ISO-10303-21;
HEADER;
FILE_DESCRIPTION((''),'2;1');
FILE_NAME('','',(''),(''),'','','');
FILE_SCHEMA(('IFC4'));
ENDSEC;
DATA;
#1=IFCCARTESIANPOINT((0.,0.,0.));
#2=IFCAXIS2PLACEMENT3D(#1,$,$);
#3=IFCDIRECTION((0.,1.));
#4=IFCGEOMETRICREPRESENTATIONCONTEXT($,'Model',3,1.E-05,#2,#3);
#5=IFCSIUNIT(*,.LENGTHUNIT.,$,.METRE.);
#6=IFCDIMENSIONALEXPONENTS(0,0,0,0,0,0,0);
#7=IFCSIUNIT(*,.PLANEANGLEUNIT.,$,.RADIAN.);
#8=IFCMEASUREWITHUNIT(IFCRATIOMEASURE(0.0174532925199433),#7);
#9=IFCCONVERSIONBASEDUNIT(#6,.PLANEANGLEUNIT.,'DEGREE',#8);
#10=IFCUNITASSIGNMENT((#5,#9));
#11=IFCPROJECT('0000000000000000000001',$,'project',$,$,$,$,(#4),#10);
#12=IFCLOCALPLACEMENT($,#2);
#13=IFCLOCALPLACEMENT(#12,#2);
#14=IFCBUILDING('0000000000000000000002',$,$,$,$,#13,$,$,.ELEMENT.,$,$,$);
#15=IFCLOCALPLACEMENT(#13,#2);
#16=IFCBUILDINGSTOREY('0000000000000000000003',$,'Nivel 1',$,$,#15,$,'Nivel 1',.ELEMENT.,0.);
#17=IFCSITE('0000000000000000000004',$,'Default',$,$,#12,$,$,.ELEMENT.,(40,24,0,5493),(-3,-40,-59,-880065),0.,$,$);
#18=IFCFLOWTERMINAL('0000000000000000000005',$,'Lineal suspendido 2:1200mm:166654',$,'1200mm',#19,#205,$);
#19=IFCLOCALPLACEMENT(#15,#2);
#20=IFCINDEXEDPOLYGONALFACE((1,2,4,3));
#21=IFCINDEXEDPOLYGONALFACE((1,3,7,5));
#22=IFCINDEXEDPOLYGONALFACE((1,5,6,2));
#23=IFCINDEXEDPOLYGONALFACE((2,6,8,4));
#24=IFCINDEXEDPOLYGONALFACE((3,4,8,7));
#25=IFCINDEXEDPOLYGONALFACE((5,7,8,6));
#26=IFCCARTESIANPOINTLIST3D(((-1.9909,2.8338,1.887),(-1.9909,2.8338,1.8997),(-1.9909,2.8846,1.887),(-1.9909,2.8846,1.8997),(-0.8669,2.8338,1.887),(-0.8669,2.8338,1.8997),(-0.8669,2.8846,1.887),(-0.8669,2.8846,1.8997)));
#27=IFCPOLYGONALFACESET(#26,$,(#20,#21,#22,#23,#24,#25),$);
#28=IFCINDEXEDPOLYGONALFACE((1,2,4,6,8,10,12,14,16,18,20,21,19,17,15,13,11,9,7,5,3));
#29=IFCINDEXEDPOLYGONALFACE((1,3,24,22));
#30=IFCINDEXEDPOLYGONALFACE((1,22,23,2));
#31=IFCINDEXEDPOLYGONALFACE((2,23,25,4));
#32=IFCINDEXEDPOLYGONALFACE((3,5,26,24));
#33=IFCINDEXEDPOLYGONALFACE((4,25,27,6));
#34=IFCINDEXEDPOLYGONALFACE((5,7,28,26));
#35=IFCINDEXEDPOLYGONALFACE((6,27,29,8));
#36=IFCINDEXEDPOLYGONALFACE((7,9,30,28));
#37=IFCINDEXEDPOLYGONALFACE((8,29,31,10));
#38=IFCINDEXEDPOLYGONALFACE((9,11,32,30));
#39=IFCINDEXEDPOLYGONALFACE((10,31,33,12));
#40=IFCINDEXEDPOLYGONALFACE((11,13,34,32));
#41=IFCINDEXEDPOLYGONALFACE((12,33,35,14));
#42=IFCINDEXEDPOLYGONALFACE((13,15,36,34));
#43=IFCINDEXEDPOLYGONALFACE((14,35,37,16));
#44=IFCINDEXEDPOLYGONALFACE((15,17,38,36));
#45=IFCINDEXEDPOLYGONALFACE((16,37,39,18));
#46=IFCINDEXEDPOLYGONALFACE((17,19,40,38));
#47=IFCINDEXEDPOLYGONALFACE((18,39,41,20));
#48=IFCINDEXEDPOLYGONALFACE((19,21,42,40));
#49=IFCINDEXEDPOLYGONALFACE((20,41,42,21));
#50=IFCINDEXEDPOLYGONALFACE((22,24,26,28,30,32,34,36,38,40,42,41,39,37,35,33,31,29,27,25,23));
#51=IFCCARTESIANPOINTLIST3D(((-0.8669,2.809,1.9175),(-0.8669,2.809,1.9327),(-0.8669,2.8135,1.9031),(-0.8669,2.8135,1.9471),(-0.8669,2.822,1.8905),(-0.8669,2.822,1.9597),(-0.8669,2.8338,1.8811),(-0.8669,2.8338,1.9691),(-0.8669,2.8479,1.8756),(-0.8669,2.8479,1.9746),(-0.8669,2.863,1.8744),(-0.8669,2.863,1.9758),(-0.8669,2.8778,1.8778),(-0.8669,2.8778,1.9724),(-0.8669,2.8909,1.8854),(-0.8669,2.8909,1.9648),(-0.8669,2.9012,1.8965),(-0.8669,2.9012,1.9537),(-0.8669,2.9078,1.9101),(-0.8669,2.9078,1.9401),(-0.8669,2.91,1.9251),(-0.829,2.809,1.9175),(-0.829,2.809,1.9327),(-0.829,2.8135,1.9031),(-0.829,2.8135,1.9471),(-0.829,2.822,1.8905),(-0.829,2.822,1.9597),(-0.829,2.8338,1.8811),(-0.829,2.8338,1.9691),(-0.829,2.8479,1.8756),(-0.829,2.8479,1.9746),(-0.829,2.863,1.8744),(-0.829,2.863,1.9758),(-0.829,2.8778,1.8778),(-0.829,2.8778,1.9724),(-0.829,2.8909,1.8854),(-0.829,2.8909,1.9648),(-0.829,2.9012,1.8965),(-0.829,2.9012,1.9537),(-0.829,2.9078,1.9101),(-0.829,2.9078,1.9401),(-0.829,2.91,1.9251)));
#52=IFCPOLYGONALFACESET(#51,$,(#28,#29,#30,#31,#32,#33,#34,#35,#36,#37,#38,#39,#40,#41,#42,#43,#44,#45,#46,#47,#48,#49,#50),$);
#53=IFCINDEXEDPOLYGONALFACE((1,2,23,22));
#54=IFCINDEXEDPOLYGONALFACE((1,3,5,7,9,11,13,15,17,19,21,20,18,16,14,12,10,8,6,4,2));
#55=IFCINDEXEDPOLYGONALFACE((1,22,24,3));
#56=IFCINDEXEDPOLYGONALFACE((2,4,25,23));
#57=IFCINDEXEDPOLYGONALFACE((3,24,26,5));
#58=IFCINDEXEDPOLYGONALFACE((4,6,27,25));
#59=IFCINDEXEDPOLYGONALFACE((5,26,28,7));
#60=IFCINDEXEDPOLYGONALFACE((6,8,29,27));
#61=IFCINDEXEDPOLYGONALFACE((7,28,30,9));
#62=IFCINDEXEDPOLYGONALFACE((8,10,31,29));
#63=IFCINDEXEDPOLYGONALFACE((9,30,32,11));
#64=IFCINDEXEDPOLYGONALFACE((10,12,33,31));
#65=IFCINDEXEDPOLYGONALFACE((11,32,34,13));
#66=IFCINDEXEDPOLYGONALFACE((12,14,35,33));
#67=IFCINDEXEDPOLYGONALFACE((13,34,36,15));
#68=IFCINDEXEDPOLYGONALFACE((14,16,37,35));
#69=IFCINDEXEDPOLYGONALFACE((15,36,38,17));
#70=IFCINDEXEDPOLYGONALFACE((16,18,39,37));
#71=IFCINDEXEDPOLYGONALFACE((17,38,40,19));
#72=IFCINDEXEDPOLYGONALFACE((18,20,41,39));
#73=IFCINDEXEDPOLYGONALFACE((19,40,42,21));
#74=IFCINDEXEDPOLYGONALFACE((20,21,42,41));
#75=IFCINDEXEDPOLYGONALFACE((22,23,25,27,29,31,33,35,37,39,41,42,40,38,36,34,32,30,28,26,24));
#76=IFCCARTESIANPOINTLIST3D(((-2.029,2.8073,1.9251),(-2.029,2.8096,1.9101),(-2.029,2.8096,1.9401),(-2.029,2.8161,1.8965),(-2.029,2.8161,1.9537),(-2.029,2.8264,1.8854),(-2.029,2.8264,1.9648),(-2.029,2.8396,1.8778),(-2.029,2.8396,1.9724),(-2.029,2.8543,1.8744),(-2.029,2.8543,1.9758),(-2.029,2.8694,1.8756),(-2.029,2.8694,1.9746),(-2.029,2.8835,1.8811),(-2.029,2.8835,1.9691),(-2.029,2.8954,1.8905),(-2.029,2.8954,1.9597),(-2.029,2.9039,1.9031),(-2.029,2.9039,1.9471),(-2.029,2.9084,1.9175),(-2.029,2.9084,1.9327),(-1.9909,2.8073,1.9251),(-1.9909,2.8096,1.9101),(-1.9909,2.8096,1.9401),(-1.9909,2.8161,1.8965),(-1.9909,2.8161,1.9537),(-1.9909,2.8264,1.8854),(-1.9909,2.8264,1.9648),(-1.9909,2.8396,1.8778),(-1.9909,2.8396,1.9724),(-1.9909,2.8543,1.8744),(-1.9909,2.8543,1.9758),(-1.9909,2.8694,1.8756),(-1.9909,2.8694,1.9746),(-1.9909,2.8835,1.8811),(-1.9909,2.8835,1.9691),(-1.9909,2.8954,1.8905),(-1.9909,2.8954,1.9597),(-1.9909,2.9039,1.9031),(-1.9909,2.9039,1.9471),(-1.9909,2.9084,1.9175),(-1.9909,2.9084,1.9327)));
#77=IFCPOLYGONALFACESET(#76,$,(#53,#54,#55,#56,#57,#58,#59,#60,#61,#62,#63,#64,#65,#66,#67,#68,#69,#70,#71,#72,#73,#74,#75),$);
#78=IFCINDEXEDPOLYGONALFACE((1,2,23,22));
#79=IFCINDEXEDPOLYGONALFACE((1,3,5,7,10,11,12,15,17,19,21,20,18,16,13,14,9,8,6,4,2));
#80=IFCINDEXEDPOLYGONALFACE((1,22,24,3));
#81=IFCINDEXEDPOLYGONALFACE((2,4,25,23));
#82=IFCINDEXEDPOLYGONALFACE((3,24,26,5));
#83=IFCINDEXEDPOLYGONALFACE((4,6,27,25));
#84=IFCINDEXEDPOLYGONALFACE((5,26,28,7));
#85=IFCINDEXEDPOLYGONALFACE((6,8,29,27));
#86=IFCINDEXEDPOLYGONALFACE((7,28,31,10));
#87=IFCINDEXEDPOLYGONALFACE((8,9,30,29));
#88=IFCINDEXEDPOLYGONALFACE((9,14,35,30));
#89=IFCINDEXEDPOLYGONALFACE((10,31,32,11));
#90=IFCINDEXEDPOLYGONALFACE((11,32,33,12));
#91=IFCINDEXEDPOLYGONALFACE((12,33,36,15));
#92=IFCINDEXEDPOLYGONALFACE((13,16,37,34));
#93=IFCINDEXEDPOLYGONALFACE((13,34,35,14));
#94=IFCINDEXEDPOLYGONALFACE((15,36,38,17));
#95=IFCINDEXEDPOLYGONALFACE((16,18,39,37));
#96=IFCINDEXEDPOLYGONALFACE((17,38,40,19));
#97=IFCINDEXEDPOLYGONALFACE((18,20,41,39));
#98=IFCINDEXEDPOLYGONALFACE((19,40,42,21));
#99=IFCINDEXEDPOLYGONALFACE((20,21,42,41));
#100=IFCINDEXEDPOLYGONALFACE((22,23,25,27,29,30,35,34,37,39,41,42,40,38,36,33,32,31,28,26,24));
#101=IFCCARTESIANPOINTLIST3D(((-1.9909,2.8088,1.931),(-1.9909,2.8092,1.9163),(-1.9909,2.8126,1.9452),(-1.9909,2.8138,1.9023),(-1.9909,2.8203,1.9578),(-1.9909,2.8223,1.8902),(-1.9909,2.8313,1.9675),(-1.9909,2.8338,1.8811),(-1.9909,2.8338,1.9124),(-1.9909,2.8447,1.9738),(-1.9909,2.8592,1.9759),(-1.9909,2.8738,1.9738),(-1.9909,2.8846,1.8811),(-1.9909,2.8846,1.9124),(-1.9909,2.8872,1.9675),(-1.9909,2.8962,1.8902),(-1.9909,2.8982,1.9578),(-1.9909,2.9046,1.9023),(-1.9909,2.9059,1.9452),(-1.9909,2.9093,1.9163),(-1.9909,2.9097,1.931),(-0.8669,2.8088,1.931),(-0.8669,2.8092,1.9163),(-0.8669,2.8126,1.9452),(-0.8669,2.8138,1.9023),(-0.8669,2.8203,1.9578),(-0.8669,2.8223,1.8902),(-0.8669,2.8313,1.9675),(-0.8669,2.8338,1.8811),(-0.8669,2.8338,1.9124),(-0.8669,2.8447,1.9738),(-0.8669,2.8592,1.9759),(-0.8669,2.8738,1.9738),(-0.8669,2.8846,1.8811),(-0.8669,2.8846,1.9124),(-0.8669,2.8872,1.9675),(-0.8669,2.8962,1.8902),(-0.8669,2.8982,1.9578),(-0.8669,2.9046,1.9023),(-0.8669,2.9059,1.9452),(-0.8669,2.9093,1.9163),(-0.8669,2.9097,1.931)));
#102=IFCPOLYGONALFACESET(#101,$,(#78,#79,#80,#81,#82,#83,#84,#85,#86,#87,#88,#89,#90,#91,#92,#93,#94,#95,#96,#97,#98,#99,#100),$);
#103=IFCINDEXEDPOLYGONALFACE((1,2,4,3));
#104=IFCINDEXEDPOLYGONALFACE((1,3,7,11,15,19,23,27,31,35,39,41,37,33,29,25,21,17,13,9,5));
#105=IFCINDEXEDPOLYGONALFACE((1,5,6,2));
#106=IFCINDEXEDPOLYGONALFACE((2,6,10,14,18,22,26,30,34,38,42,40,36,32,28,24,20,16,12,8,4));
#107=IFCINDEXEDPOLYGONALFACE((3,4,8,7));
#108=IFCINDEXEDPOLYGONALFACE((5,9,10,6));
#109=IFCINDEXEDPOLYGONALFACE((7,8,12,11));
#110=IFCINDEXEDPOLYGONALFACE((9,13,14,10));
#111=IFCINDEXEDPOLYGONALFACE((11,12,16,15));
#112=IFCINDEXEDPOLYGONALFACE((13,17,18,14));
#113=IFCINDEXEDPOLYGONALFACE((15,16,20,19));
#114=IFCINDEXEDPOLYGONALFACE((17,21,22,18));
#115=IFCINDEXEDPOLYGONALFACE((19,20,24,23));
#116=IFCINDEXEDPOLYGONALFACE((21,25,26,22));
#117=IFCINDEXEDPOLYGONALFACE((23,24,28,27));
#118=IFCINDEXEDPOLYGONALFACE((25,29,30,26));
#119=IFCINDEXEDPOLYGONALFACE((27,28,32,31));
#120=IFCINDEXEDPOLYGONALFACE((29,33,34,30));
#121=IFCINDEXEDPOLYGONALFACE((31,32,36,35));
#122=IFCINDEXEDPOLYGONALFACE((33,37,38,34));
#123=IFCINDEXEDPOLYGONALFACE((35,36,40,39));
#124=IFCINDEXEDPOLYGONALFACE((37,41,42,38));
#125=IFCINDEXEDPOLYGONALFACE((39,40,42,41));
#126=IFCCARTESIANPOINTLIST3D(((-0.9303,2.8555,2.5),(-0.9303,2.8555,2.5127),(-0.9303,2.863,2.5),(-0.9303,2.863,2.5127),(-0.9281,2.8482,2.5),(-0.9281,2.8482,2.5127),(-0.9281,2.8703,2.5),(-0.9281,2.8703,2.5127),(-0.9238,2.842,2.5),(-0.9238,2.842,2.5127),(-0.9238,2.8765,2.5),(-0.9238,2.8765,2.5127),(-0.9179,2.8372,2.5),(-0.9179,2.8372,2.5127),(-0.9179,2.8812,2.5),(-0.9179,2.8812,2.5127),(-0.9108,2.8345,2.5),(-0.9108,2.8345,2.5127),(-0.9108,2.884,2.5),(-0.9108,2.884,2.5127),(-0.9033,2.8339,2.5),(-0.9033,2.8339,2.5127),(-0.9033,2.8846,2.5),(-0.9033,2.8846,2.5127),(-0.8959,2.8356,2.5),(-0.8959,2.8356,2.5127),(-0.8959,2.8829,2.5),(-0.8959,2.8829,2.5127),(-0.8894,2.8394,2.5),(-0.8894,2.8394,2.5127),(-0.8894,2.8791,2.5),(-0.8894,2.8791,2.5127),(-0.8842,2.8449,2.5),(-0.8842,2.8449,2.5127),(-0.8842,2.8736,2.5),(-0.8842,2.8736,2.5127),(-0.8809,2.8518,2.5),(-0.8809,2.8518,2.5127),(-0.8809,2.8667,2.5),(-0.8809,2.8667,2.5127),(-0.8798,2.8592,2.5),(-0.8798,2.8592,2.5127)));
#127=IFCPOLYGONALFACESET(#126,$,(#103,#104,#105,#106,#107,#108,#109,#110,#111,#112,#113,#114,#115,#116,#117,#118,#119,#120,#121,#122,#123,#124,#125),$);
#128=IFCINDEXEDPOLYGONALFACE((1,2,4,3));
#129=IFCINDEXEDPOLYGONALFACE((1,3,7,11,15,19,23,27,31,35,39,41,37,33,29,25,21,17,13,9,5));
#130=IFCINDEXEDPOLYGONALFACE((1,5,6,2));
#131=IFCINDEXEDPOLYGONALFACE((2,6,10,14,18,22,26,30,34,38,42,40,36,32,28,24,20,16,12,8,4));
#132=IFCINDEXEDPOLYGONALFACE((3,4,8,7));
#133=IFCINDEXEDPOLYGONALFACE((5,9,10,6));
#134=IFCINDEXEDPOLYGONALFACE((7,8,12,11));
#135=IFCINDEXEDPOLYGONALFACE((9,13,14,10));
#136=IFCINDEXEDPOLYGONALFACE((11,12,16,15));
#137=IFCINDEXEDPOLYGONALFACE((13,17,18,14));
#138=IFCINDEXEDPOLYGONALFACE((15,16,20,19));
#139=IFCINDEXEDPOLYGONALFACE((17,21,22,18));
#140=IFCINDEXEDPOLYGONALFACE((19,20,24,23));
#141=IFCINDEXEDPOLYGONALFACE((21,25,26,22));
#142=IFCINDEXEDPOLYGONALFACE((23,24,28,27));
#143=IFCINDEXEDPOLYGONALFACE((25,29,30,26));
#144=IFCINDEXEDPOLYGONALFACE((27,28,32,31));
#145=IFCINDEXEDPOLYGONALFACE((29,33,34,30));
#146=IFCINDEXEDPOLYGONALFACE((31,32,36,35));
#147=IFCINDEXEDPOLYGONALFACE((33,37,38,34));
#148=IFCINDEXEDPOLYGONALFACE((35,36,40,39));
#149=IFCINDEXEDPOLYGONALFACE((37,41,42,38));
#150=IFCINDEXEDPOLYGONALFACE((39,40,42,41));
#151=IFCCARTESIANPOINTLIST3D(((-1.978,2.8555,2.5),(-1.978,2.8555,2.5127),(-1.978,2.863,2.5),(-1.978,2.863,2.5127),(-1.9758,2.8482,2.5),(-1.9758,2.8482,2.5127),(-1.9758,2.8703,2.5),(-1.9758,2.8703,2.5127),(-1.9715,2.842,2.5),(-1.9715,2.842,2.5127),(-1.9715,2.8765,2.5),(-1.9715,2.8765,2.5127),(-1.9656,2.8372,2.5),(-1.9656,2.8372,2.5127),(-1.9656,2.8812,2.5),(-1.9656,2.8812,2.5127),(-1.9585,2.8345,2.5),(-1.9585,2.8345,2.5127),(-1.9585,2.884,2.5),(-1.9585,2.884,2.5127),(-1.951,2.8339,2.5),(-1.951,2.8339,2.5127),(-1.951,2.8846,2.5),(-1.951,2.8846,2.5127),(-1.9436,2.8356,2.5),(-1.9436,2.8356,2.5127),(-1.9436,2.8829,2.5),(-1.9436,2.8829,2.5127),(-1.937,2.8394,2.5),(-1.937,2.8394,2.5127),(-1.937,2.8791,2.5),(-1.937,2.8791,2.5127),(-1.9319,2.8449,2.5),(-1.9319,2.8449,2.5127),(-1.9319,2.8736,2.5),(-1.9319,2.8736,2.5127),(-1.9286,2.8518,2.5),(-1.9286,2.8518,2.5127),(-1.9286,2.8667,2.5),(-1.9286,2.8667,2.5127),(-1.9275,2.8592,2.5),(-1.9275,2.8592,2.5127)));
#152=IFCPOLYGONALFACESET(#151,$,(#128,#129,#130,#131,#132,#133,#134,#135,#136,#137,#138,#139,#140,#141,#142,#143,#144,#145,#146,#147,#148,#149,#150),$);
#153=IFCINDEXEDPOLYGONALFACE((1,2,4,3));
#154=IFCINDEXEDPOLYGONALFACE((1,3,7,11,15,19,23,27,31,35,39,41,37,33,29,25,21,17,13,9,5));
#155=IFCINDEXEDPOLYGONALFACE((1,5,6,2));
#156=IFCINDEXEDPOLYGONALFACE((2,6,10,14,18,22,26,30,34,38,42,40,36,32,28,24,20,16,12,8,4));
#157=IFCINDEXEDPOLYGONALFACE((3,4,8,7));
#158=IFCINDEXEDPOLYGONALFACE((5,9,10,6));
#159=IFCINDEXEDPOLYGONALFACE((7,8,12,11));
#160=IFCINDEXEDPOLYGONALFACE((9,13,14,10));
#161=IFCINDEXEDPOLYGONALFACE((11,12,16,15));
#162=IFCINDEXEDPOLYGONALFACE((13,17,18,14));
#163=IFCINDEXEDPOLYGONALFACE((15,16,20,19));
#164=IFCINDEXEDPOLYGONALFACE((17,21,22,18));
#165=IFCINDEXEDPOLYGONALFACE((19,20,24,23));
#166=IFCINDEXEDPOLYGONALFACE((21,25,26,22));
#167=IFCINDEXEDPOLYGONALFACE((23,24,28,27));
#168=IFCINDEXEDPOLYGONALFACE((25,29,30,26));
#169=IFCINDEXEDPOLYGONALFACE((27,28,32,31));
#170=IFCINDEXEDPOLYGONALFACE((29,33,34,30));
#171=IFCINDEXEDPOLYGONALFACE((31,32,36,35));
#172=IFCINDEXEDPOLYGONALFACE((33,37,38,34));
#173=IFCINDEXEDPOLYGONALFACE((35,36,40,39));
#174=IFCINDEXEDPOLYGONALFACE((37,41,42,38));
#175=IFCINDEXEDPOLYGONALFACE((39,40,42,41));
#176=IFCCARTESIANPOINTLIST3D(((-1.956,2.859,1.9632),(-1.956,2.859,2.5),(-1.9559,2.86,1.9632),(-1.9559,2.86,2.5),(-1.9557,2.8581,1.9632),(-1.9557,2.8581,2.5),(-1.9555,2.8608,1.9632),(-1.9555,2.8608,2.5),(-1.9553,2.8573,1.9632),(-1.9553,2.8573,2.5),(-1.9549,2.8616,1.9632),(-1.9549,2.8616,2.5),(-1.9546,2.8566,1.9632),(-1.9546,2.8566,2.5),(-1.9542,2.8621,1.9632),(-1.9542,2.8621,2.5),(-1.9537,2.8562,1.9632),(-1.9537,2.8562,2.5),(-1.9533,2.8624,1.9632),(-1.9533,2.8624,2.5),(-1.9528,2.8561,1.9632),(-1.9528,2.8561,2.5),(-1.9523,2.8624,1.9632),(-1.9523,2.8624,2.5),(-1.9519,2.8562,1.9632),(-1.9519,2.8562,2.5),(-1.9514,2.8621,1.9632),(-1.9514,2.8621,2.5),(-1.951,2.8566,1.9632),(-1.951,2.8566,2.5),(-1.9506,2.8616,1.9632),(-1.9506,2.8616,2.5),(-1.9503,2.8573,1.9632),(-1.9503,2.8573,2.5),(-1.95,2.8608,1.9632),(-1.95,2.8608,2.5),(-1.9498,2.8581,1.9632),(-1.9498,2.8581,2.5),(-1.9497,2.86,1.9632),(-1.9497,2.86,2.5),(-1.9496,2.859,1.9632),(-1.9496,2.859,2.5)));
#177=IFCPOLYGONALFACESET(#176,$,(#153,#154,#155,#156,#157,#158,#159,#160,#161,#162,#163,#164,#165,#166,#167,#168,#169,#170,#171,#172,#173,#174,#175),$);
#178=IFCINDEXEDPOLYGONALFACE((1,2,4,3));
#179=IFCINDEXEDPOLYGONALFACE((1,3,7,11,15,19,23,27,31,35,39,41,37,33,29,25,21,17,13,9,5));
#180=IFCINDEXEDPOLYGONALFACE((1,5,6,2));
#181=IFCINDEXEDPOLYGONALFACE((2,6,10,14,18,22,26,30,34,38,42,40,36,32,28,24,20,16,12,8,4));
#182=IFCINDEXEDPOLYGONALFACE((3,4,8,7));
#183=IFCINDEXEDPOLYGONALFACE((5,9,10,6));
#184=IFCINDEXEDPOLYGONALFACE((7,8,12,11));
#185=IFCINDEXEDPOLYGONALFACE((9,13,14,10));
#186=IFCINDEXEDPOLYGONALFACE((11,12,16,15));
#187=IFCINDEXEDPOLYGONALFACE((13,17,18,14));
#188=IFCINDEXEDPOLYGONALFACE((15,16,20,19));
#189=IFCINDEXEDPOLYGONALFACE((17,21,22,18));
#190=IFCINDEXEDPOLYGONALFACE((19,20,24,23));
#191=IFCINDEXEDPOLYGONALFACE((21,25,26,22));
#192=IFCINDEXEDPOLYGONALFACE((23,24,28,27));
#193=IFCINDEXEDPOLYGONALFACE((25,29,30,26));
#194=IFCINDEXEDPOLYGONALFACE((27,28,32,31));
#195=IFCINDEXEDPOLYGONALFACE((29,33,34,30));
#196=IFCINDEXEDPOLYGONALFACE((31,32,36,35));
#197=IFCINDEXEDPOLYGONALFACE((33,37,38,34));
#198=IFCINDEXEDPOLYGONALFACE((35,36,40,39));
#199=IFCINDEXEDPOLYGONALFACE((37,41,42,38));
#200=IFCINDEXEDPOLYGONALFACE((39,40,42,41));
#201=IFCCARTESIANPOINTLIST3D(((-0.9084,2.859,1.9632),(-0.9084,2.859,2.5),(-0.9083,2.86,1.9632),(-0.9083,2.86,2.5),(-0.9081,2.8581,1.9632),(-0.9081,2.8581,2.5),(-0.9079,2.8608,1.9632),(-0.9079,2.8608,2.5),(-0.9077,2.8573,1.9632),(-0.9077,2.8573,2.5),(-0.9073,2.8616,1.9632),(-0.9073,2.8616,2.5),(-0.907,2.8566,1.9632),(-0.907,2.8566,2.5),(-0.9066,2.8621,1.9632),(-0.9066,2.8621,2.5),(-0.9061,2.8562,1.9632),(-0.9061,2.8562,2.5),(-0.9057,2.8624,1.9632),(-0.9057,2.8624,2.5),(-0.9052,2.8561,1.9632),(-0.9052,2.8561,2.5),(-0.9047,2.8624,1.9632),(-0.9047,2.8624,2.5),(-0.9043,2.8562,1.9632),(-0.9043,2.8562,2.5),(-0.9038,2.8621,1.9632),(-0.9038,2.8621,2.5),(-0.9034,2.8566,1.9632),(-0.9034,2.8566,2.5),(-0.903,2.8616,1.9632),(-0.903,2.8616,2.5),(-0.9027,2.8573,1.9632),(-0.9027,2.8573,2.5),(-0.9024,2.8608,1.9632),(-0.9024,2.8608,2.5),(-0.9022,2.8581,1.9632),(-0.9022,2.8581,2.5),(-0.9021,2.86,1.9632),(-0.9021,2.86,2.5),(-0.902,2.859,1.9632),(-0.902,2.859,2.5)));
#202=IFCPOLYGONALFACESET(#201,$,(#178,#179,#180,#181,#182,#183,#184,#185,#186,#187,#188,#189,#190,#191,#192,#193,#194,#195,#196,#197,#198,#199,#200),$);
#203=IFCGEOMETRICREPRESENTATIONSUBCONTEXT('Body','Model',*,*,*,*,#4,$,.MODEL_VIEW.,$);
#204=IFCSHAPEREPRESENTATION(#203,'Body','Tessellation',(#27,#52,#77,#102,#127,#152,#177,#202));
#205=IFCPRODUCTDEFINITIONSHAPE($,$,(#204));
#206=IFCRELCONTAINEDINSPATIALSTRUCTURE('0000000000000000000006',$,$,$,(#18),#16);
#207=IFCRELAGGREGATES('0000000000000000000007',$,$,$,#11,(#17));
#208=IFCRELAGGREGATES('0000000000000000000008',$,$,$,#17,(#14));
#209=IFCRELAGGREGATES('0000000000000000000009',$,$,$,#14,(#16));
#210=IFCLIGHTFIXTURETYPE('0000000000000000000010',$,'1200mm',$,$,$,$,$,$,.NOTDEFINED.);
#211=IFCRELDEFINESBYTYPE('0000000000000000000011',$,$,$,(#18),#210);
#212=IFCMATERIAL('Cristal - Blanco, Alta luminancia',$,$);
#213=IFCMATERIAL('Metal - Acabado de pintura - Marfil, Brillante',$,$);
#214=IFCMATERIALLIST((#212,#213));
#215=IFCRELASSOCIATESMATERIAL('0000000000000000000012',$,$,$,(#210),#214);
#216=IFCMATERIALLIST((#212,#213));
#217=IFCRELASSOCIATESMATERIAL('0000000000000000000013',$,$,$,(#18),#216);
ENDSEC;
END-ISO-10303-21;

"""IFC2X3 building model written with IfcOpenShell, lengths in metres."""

from ifc_helpers import new_model, entity, si_unit, converted_unit, direction, frame, frame_2d, origin, origin_2d_with_axis, place, context, subcontext, project, spatial, polyline, circle_curve, parameter, trimmed, segment, composite_curve, rectangle, circle, outline, extrude, source, transform, mapped, material, material_list, type_object, type_shapes, element, save


model = new_model("IFC2X3")

# Units and contexts
model_context = context("Model", 3, precision=1e-05, world=origin(), true_north=direction((0.0, 1.0)))
body_context = subcontext(model_context, "Body", "Model", "MODEL_VIEW")
ifc_project = project(units=[si_unit("LENGTHUNIT", "METRE"), converted_unit("PLANEANGLEUNIT", "DEGREE", entity("IfcRatioMeasure", 0.0174532925199433), si_unit("PLANEANGLEUNIT", "RADIAN"), dimensions=[0, 0, 0, 0, 0, 0, 0])], contexts=[model_context])

# Site, building, storey
site_placement = place(None, origin())
site = spatial("IfcSite", under=ifc_project, at=site_placement, Name="Default", CompositionType="ELEMENT", RefLatitude=(40, 24, 0, 5493), RefLongitude=(-3, -40, -59, -880065), RefElevation=0.0)
building_placement = place(site_placement, origin())
building = spatial("IfcBuilding", under=site, at=building_placement, CompositionType="ELEMENT")
storey_placement = place(building_placement, origin())
storey = spatial("IfcBuildingStorey", under=building, at=storey_placement, Name="Nivel 1", LongName="Nivel 1", CompositionType="ELEMENT", Elevation=0.0)

# Flow terminal
ifc_material_1 = material(Name="Cristal - Blanco, Alta luminancia")
ifc_material_2 = material(Name="Metal - Acabado de pintura - Marfil, Brillante")
ifc_material_list_1 = material_list([ifc_material_1, ifc_material_2])
light_fixture_type = type_object("IfcLightFixtureType", Name="1200mm", PredefinedType="NOTDEFINED", material=ifc_material_list_1)
shared_shape = source(origin(), body_context, "Body", "SweptSolid", [
    extrude(rectangle(XDim=1.124, YDim=0.0508, at=origin_2d_with_axis()), frame((0.0001, 0.0, 1.8127), z_axis=(0.0, 0.0, 1.0), x_axis=(-1.0, 0.0, 0.0)), (0.0, 0.0, 1.0), 0.0127),
    extrude(circle(Radius=0.0508, at=frame_2d((0.0, 0.0), x_axis=(1.0, 0.0))), frame((0.5621, 0.0, 1.8508), z_axis=(1.0, 0.0, 0.0), x_axis=(0.0, 1.0, 0.0)), (0.0, 0.0, 1.0), 0.0379),
    extrude(circle(Radius=0.0508, at=frame_2d((0.0, 0.0), x_axis=(1.0, 0.0))), frame((-0.6, -0.0011, 1.8508), z_axis=(1.0, 0.0, 0.0), x_axis=(0.0, -1.0, 0.0)), (0.0, 0.0, 1.0), 0.0381),
    extrude(outline(composite_curve([segment(trimmed(circle_curve(frame_2d((0.0125, 0.0), x_axis=(0.0, 1.0)), 0.0508), [parameter(120.0)], [parameter(270.0)], True, "PARAMETER"), True, "CONTINUOUS"), segment(trimmed(circle_curve(frame_2d((0.0125, 0.0), x_axis=(0.0, 1.0)), 0.0508), [parameter(270.0)], [parameter(60.0)], True, "PARAMETER"), True, "CONTINUOUS"), segment(polyline([(-0.0315, 0.0254), (-0.0002, 0.0254)]), True, "CONTINUOUS"), segment(polyline([(-0.0002, 0.0254), (-0.0002, -0.0254)]), True, "CONTINUOUS"), segment(polyline([(-0.0002, -0.0254), (-0.0315, -0.0254)]), True, "CONTINUOUS")], self_intersect=False)), frame((-0.5619, 0.0, 1.8383), z_axis=(-1.0, 0.0, 0.0), x_axis=(0.0, 0.0, 1.0)), (0.0, 0.0, -1.0), 1.124),
    extrude(circle(Radius=0.0254, at=frame_2d((0.0, 0.0), x_axis=(1.0, 0.0))), frame((0.5238, 0.0, 2.4257)), (0.0, 0.0, 1.0), 0.0127),
    extrude(circle(Radius=0.0254, at=frame_2d((0.0, 0.0), x_axis=(1.0, 0.0))), frame((-0.5239, 0.0, 2.4257)), (0.0, 0.0, 1.0), 0.0127),
    extrude(circle(Radius=0.0032, at=frame_2d((0.0, 0.0), x_axis=(1.0, 0.0))), frame((-0.5238, 0.0, 1.8889), z_axis=(0.0, 0.0, 1.0), x_axis=(0.0, -1.0, 0.0)), (0.0, 0.0, 1.0), 0.5368),
    extrude(circle(Radius=0.0032, at=frame_2d((0.0, 0.0), x_axis=(1.0, 0.0))), frame((0.5238, 0.0, 1.8889), z_axis=(0.0, 0.0, 1.0), x_axis=(0.0, -1.0, 0.0)), (0.0, 0.0, 1.0), 0.5368),
])
type_shapes(light_fixture_type, [shared_shape])
ifc_material_list_2 = material_list([ifc_material_1, ifc_material_2])
flow_terminal_1_placement = place(storey_placement, frame((-1.429, 2.8592, 0.0743)))
element("IfcFlowTerminal", 1, at=flow_terminal_1_placement, inside=storey, type_object=light_fixture_type, material=ifc_material_list_2, Name="Lineal suspendido 2:1200mm:166654", ObjectType="1200mm", context=body_context, shape_type="MappedRepresentation", body=[
    mapped(shared_shape, transform((0.0, 0.0, 0.0), scale=1.0)),
])

save(model, "model.ifc")
